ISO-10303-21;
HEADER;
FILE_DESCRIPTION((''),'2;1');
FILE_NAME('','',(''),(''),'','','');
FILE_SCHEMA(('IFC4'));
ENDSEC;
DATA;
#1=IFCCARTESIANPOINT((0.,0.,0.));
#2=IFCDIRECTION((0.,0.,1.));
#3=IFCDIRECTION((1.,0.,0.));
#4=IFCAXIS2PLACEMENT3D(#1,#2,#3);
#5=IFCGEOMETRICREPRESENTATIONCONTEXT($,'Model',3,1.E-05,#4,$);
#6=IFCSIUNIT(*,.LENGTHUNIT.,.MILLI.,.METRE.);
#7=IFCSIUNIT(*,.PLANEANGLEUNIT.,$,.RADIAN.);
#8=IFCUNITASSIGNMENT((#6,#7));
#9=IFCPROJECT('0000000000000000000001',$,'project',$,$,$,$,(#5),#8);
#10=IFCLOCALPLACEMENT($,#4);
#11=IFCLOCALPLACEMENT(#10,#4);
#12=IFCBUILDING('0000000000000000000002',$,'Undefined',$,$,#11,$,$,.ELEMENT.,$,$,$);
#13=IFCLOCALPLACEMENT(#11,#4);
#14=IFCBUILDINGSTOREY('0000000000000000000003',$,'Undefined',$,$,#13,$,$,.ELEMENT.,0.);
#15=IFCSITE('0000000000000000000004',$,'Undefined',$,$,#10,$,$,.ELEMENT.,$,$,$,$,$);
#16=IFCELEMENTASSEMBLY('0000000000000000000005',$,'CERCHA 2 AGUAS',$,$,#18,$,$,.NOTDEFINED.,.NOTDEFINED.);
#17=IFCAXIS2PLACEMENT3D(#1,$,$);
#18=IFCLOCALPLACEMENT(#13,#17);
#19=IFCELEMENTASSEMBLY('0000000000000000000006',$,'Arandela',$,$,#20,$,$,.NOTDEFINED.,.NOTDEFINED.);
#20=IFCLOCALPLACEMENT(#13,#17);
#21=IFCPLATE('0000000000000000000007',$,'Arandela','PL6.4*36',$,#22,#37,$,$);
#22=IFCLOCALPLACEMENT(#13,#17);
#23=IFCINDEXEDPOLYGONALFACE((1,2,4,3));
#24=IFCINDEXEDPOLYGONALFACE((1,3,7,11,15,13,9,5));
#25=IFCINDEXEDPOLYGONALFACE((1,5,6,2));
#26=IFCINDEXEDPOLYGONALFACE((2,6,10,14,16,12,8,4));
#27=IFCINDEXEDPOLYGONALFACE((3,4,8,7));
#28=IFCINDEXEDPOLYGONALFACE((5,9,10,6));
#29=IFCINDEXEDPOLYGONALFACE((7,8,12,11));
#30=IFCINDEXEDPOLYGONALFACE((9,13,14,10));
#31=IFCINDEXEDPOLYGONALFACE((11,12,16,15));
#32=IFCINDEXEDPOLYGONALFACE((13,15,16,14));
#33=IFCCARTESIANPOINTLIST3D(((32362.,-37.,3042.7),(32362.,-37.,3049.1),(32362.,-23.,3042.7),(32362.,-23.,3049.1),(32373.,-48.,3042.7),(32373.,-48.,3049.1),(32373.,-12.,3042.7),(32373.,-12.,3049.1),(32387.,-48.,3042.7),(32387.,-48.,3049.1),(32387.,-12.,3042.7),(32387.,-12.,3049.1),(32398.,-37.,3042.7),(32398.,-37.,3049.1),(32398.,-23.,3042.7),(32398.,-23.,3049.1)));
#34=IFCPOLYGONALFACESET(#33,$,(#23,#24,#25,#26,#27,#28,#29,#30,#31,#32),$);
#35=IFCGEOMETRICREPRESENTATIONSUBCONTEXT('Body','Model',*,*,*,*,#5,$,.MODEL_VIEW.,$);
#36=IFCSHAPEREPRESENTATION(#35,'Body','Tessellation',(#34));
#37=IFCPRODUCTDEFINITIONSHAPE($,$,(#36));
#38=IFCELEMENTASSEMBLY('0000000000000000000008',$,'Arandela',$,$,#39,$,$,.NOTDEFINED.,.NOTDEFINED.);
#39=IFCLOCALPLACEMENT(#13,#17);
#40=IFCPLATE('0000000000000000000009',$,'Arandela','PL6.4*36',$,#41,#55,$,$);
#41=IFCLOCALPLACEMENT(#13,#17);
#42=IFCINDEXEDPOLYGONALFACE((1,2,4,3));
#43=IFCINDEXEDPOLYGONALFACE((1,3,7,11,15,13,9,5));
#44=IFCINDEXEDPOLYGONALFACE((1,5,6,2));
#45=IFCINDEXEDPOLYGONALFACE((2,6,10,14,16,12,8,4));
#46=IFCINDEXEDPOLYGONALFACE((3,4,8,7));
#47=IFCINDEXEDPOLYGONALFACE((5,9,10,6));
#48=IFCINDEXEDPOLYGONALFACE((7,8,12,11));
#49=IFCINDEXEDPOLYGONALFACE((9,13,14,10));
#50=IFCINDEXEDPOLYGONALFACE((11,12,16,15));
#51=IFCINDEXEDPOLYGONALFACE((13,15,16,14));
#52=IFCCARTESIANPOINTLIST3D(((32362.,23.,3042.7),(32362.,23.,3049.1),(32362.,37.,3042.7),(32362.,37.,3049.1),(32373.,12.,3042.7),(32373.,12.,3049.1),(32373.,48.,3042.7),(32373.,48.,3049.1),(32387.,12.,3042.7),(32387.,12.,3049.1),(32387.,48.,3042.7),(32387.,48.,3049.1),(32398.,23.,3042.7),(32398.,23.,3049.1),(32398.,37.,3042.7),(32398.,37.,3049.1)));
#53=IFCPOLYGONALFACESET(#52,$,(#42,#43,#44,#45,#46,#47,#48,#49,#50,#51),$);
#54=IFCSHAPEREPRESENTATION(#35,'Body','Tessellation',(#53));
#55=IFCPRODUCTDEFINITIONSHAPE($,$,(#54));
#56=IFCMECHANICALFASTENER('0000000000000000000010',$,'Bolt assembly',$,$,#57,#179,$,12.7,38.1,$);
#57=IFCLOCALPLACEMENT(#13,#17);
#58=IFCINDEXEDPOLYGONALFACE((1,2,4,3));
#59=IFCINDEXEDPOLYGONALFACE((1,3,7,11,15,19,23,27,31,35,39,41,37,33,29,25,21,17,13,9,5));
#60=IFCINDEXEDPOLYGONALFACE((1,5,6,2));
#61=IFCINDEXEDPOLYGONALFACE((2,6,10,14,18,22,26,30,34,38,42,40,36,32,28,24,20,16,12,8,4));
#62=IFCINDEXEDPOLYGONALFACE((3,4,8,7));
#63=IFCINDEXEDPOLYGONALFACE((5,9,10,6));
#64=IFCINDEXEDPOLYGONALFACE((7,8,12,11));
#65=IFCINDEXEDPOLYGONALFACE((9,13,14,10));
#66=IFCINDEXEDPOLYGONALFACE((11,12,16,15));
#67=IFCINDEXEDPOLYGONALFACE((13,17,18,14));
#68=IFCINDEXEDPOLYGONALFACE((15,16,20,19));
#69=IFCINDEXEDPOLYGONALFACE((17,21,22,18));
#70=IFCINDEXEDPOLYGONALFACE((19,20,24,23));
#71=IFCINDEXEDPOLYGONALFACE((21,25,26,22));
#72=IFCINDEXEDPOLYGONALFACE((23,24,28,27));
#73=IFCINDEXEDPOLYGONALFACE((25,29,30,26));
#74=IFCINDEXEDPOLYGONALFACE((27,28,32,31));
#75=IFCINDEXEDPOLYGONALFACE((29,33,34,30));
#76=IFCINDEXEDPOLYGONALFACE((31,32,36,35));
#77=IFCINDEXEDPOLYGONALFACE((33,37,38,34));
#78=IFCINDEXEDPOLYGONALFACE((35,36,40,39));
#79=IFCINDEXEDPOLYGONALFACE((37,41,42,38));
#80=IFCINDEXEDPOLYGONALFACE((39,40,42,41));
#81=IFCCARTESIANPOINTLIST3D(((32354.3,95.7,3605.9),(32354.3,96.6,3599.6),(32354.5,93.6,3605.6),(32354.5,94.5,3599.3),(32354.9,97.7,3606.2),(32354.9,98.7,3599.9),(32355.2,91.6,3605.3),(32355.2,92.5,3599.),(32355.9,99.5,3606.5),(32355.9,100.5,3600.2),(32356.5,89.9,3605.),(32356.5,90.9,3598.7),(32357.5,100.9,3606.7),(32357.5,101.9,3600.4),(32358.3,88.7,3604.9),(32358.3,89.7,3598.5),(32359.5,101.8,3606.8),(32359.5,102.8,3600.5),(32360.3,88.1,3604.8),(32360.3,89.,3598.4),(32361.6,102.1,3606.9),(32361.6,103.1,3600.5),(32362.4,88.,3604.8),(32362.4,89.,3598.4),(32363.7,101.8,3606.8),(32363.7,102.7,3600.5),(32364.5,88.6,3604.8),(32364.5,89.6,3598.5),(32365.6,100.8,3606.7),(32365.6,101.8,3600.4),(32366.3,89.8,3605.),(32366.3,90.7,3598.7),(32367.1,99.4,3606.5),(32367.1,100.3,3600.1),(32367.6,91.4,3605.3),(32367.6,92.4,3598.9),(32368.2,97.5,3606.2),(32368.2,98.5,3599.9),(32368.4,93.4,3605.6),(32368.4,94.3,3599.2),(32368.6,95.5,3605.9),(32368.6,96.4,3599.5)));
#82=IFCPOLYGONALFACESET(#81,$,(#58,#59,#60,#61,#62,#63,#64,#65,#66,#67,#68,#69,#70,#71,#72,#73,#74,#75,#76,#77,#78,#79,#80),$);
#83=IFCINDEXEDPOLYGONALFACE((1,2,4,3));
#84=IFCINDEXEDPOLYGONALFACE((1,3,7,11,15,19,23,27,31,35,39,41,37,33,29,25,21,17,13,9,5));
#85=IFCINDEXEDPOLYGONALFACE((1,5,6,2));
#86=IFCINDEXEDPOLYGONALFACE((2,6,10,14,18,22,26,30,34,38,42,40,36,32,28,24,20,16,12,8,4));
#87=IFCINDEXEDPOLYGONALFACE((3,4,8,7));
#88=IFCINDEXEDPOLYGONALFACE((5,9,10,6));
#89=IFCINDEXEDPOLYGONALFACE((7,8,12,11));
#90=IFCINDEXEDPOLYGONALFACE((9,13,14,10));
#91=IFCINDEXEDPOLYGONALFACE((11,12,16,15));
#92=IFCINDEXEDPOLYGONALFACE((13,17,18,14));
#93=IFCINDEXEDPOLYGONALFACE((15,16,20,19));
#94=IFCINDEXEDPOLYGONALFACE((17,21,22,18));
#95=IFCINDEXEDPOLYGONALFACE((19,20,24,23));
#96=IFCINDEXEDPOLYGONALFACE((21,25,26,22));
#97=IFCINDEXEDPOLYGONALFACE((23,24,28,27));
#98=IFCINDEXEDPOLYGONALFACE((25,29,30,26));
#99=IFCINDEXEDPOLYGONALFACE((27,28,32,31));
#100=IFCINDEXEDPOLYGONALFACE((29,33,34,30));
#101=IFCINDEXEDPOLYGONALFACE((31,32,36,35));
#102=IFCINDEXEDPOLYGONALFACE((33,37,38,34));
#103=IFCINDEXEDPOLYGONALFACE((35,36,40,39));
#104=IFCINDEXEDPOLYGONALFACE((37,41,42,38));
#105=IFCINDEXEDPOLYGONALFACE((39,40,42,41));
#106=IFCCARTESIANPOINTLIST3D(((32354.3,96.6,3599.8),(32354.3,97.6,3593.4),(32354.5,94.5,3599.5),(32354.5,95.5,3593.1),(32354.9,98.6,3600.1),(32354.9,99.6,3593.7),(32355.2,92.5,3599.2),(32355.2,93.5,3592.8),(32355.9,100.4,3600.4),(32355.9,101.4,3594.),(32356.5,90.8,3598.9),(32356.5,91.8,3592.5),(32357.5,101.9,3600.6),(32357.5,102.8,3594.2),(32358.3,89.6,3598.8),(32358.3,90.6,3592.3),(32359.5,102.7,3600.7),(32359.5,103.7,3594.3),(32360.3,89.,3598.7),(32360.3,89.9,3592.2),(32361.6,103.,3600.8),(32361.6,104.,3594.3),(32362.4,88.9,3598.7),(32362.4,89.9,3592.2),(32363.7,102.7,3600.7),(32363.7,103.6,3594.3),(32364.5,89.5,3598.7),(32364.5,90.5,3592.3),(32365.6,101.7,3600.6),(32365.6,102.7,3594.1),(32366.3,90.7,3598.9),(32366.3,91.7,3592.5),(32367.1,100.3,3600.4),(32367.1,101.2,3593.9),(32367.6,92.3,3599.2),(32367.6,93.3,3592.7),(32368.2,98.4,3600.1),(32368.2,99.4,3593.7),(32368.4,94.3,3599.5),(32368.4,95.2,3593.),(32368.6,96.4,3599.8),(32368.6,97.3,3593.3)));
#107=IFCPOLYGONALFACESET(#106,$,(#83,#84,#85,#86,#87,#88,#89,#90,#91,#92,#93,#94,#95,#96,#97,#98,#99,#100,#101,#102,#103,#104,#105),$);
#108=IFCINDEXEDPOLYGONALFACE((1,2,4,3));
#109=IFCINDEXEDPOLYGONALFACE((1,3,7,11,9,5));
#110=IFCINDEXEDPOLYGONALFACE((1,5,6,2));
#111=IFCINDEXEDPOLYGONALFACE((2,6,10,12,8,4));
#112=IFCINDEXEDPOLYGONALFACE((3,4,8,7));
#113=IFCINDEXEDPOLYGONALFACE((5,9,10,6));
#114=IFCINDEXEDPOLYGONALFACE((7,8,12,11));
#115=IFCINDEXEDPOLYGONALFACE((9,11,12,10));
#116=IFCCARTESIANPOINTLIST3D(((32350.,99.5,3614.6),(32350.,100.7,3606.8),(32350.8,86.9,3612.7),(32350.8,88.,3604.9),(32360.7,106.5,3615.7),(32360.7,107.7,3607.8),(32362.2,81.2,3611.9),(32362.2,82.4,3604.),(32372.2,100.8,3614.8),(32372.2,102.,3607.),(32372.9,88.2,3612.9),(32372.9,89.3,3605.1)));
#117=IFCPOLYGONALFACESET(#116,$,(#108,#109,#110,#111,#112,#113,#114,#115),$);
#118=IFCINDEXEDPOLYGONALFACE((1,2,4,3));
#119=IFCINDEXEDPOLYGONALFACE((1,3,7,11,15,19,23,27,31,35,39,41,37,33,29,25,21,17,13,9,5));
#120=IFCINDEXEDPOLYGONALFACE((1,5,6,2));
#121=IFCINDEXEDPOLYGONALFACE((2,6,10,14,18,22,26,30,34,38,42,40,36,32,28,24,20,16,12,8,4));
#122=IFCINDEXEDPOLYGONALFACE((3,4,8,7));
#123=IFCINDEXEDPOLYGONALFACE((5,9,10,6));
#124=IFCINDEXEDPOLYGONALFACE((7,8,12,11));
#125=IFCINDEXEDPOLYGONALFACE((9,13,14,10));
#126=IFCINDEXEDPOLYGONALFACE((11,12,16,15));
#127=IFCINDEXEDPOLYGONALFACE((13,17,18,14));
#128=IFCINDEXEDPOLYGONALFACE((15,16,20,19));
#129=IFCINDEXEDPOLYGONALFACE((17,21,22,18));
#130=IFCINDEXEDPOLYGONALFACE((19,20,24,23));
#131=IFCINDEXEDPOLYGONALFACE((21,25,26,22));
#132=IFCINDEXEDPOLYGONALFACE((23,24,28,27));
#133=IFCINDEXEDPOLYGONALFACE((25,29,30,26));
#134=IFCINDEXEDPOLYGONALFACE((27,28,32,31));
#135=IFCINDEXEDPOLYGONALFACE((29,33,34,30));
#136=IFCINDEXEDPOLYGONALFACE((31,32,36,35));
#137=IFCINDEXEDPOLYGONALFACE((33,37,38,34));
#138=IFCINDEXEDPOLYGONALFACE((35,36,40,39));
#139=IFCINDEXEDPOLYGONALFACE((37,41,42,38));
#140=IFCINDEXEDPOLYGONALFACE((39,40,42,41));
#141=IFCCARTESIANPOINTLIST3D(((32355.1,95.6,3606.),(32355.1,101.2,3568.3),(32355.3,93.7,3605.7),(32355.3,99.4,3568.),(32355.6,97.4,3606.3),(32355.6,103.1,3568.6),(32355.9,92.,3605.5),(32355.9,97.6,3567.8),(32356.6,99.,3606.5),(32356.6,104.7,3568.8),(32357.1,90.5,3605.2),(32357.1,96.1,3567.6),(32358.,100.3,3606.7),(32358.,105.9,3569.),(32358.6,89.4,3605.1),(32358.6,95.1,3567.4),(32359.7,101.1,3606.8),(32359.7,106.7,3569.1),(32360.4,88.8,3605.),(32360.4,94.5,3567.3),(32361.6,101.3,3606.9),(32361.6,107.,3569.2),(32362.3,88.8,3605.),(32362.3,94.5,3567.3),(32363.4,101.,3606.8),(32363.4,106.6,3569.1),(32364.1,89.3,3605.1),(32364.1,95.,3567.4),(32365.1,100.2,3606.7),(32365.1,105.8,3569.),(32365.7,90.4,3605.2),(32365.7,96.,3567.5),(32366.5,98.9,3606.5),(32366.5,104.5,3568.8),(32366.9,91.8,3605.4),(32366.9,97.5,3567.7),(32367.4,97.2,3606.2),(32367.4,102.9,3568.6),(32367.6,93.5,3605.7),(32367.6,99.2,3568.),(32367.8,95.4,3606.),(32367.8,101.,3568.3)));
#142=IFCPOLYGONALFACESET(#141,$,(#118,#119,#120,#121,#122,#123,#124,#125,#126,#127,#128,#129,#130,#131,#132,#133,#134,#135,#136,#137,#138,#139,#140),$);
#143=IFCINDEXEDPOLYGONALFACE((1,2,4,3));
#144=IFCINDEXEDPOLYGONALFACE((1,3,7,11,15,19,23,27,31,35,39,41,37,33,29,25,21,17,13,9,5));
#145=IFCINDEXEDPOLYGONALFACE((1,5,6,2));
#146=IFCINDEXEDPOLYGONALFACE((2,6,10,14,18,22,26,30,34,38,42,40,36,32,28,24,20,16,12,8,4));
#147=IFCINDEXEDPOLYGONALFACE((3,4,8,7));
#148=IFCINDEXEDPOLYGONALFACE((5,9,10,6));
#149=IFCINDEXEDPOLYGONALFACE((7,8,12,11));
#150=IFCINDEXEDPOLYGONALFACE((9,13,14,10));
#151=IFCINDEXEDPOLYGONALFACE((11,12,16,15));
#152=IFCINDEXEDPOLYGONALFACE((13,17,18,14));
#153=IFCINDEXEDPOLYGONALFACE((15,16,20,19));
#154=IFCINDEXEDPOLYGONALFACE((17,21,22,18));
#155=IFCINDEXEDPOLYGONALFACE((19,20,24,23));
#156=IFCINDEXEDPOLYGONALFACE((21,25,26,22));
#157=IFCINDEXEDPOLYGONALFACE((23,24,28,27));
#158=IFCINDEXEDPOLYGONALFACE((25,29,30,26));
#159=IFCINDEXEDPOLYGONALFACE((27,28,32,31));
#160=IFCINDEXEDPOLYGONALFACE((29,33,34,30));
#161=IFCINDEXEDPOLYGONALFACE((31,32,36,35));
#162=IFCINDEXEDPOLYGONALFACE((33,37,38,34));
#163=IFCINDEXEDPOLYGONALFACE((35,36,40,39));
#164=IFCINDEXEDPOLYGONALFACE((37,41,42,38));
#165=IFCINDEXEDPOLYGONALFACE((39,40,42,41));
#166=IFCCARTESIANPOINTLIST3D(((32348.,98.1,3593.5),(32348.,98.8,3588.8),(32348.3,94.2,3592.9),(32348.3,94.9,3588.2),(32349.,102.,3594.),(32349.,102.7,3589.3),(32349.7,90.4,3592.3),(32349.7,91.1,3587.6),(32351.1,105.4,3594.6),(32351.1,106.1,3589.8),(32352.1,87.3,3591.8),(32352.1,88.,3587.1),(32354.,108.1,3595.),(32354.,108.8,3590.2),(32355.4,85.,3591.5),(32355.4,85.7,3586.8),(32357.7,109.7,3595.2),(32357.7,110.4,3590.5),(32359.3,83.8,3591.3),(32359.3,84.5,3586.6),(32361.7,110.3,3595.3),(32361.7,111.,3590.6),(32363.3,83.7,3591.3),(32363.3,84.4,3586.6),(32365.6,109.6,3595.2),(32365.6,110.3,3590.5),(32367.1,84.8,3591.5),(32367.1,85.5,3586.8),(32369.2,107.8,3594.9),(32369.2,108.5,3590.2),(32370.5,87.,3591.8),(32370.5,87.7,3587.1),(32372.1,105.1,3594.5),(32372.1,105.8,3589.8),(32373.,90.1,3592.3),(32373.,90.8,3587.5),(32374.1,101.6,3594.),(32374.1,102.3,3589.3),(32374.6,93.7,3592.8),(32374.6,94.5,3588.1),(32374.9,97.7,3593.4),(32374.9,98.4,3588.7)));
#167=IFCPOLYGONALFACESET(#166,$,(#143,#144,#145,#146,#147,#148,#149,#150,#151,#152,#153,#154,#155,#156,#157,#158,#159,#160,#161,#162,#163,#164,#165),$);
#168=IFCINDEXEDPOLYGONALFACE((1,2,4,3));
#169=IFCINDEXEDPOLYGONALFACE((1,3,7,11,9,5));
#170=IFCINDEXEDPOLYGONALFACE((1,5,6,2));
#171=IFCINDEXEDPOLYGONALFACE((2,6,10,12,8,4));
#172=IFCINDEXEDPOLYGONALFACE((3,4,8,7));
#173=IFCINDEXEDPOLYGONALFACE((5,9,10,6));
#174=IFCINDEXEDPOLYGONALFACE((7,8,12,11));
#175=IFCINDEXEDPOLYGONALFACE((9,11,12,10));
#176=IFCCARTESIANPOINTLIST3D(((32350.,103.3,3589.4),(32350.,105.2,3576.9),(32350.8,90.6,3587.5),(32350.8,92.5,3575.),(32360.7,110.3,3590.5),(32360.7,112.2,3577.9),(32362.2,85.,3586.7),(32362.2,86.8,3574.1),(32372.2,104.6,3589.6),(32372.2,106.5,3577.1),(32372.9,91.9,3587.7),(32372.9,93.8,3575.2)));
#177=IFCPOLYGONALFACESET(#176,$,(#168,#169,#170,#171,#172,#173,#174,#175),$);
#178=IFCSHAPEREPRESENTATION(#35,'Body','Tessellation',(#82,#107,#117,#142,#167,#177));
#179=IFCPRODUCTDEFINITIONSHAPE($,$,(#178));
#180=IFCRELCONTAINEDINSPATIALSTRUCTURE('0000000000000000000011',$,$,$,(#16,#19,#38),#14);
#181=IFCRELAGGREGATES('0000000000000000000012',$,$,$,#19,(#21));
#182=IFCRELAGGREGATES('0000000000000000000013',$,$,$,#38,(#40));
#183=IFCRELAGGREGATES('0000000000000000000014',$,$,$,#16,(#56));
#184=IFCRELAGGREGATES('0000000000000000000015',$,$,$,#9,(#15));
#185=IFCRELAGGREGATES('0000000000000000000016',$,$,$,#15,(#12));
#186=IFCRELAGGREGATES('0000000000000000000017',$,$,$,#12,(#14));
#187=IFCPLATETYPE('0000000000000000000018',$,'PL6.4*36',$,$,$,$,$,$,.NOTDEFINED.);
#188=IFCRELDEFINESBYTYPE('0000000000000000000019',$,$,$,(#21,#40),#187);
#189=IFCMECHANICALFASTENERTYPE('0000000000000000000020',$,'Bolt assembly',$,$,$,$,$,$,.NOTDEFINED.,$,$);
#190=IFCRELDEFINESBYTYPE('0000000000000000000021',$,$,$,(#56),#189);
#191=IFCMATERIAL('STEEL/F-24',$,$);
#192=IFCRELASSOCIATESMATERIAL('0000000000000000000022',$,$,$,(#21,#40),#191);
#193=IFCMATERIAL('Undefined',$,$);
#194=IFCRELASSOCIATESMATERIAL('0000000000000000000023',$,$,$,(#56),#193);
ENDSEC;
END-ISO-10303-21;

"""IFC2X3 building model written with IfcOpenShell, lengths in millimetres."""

from ifc_helpers import new_model, si_unit, frame, origin_with_axes, origin_2d_with_axis, place, context, subcontext, project, spatial, polyline, circle, outline, extrude, source, transform, mapped, material, type_object, element, aggregate, save


model = new_model("IFC2X3")

# Units and contexts
model_context = context("Model", 3, precision=1e-05, world=origin_with_axes())
body_context = subcontext(model_context, "Body", "Model", "MODEL_VIEW")
ifc_project = project(units=[si_unit("LENGTHUNIT", "METRE", prefix="MILLI"), si_unit("PLANEANGLEUNIT", "RADIAN")], contexts=[model_context])

# Site, building, storey
site_placement = place(None, origin_with_axes())
site = spatial("IfcSite", under=ifc_project, at=site_placement, Name="Undefined", CompositionType="ELEMENT")
building_placement = place(site_placement, origin_with_axes())
building = spatial("IfcBuilding", under=site, at=building_placement, Name="Undefined", CompositionType="ELEMENT")
storey_placement = place(building_placement, origin_with_axes())
storey = spatial("IfcBuildingStorey", under=building, at=storey_placement, Name="Undefined", CompositionType="ELEMENT", Elevation=0.0)

# Element assembly
assembly_1_placement = place(storey_placement, origin_with_axes())
assembly_1 = element("IfcElementAssembly", 1, at=assembly_1_placement, inside=storey, Name="CERCHA 2 AGUAS", AssemblyPlace="NOTDEFINED", PredefinedType="NOTDEFINED")

# Shared definitions
ifc_material_1 = material(Name="STEEL/F-24")

# Element assemblies, plates
plate_type_1 = type_object("IfcPlateType", Name="PL6.4*36", PredefinedType="NOTDEFINED")
assembly_2_placement = place(storey_placement, origin_with_axes())
assembly_2 = element("IfcElementAssembly", 2, at=assembly_2_placement, inside=storey, Name="Arandela", AssemblyPlace="NOTDEFINED", PredefinedType="NOTDEFINED")
plate_1_placement = place(assembly_2_placement, frame((32362.0, -12.0, 3045.9), z_axis=(0.0, 0.0, 1.0), x_axis=(0.0, -1.0, 0.0)))
plate_1 = element("IfcPlate", 3, at=plate_1_placement, type_object=plate_type_1, material=ifc_material_1, Name="Arandela", Description="PL6.4*36", context=body_context, shape_type="SweptSolid", body=[
    extrude(outline(polyline([(0.0, 11.0), (11.0, 0.0), (25.0, 0.0), (36.0, 11.0), (36.0, 25.0), (25.0, 36.0), (11.0, 36.0), (0.0, 25.0), (0.0, 11.0)])), frame((0.0, 0.0, -3.2), z_axis=(0.0, 0.0, 1.0), x_axis=(1.0, 0.0, 0.0)), (0.0, 0.0, 1.0), 6.4),
])
assembly_3_placement = place(storey_placement, origin_with_axes())
assembly_3 = element("IfcElementAssembly", 4, at=assembly_3_placement, inside=storey, Name="Arandela", AssemblyPlace="NOTDEFINED", PredefinedType="NOTDEFINED")
plate_2_placement = place(assembly_3_placement, frame((32362.0, 48.0, 3045.9), z_axis=(0.0, 0.0, 1.0), x_axis=(0.0, -1.0, 0.0)))
plate_2 = element("IfcPlate", 5, at=plate_2_placement, type_object=plate_type_1, material=ifc_material_1, Name="Arandela", Description="PL6.4*36", context=body_context, shape_type="SweptSolid", body=[
    extrude(outline(polyline([(0.0, 11.0), (11.0, 0.0), (25.0, 0.0), (36.0, 11.0), (36.0, 25.0), (25.0, 36.0), (11.0, 36.0), (0.0, 25.0), (0.0, 11.0)])), frame((0.0, 0.0, -3.2), z_axis=(0.0, 0.0, 1.0), x_axis=(1.0, 0.0, 0.0)), (0.0, 0.0, 1.0), 6.4),
])

# Shared definitions
ifc_material_2 = material(Name="Undefined")
mechanical_fastener_type = type_object("IfcMechanicalFastenerType", Name="Bolt assembly")

# Mechanical fastener
shared_shape_1 = source(origin_with_axes(), body_context, "Body", "SweptSolid", [
    extrude(circle(Radius=7.1, at=origin_2d_with_axis()), frame((0.0, -6.3, 0.0), z_axis=(0.0, 1.0, 0.0), x_axis=(1.0, 0.0, 0.0)), (0.0, 0.0, 1.0), 6.4),
    extrude(circle(Radius=7.1, at=origin_2d_with_axis()), frame((0.0, -0.1, 0.0), z_axis=(0.0, 1.0, 0.0), x_axis=(1.0, 0.0, 0.0)), (0.0, 0.0, 1.0), 6.5),
    extrude(outline(polyline([(11.1, -6.4), (11.1, 6.4), (0.0, 12.8), (-11.1, 6.4), (-11.1, -6.4), (0.0, -12.8), (11.1, -6.4)])), frame((0.0, -14.3, 0.0), z_axis=(0.0, 1.0, 0.0), x_axis=(1.0, 0.0, 0.0)), (0.0, 0.0, 1.0), 7.9),
    extrude(circle(Radius=6.3, at=origin_2d_with_axis()), frame((0.0, -6.4, 0.0), z_axis=(0.0, 1.0, 0.0), x_axis=(1.0, 0.0, 0.0)), (0.0, 0.0, 1.0), 38.1),
    extrude(circle(Radius=13.5, at=origin_2d_with_axis()), frame((0.0, 6.4, 0.0), z_axis=(0.0, 1.0, 0.0), x_axis=(1.0, 0.0, 0.0)), (0.0, 0.0, 1.0), 4.8),
    extrude(outline(polyline([(11.1, -6.4), (11.1, 6.4), (0.0, 12.8), (-11.1, 6.4), (-11.1, -6.4), (0.0, -12.8), (11.1, -6.4)])), frame((0.0, 11.2, 0.0), z_axis=(0.0, 1.0, 0.0), x_axis=(1.0, 0.0, 0.0)), (0.0, 0.0, 1.0), 12.7),
])
mechanical_fastener_1_placement = place(assembly_1_placement, frame((32361.5, 96.0, 3599.6), z_axis=(-0.834881, -0.544341, -0.081651), x_axis=(-0.55043, 0.825644, 0.123847)))
mechanical_fastener_1 = element("IfcMechanicalFastener", 6, at=mechanical_fastener_1_placement, type_object=mechanical_fastener_type, material=ifc_material_2, Name="Bolt assembly", NominalDiameter=12.7, NominalLength=38.1, context=body_context, shape_type="MappedRepresentation", body=[
    mapped(shared_shape_1, transform((0.0, 0.0, 0.0))),
])
aggregate(assembly_2, [plate_1])
aggregate(assembly_3, [plate_2])
aggregate(assembly_1, [mechanical_fastener_1])

save(model, "model.ifc")
